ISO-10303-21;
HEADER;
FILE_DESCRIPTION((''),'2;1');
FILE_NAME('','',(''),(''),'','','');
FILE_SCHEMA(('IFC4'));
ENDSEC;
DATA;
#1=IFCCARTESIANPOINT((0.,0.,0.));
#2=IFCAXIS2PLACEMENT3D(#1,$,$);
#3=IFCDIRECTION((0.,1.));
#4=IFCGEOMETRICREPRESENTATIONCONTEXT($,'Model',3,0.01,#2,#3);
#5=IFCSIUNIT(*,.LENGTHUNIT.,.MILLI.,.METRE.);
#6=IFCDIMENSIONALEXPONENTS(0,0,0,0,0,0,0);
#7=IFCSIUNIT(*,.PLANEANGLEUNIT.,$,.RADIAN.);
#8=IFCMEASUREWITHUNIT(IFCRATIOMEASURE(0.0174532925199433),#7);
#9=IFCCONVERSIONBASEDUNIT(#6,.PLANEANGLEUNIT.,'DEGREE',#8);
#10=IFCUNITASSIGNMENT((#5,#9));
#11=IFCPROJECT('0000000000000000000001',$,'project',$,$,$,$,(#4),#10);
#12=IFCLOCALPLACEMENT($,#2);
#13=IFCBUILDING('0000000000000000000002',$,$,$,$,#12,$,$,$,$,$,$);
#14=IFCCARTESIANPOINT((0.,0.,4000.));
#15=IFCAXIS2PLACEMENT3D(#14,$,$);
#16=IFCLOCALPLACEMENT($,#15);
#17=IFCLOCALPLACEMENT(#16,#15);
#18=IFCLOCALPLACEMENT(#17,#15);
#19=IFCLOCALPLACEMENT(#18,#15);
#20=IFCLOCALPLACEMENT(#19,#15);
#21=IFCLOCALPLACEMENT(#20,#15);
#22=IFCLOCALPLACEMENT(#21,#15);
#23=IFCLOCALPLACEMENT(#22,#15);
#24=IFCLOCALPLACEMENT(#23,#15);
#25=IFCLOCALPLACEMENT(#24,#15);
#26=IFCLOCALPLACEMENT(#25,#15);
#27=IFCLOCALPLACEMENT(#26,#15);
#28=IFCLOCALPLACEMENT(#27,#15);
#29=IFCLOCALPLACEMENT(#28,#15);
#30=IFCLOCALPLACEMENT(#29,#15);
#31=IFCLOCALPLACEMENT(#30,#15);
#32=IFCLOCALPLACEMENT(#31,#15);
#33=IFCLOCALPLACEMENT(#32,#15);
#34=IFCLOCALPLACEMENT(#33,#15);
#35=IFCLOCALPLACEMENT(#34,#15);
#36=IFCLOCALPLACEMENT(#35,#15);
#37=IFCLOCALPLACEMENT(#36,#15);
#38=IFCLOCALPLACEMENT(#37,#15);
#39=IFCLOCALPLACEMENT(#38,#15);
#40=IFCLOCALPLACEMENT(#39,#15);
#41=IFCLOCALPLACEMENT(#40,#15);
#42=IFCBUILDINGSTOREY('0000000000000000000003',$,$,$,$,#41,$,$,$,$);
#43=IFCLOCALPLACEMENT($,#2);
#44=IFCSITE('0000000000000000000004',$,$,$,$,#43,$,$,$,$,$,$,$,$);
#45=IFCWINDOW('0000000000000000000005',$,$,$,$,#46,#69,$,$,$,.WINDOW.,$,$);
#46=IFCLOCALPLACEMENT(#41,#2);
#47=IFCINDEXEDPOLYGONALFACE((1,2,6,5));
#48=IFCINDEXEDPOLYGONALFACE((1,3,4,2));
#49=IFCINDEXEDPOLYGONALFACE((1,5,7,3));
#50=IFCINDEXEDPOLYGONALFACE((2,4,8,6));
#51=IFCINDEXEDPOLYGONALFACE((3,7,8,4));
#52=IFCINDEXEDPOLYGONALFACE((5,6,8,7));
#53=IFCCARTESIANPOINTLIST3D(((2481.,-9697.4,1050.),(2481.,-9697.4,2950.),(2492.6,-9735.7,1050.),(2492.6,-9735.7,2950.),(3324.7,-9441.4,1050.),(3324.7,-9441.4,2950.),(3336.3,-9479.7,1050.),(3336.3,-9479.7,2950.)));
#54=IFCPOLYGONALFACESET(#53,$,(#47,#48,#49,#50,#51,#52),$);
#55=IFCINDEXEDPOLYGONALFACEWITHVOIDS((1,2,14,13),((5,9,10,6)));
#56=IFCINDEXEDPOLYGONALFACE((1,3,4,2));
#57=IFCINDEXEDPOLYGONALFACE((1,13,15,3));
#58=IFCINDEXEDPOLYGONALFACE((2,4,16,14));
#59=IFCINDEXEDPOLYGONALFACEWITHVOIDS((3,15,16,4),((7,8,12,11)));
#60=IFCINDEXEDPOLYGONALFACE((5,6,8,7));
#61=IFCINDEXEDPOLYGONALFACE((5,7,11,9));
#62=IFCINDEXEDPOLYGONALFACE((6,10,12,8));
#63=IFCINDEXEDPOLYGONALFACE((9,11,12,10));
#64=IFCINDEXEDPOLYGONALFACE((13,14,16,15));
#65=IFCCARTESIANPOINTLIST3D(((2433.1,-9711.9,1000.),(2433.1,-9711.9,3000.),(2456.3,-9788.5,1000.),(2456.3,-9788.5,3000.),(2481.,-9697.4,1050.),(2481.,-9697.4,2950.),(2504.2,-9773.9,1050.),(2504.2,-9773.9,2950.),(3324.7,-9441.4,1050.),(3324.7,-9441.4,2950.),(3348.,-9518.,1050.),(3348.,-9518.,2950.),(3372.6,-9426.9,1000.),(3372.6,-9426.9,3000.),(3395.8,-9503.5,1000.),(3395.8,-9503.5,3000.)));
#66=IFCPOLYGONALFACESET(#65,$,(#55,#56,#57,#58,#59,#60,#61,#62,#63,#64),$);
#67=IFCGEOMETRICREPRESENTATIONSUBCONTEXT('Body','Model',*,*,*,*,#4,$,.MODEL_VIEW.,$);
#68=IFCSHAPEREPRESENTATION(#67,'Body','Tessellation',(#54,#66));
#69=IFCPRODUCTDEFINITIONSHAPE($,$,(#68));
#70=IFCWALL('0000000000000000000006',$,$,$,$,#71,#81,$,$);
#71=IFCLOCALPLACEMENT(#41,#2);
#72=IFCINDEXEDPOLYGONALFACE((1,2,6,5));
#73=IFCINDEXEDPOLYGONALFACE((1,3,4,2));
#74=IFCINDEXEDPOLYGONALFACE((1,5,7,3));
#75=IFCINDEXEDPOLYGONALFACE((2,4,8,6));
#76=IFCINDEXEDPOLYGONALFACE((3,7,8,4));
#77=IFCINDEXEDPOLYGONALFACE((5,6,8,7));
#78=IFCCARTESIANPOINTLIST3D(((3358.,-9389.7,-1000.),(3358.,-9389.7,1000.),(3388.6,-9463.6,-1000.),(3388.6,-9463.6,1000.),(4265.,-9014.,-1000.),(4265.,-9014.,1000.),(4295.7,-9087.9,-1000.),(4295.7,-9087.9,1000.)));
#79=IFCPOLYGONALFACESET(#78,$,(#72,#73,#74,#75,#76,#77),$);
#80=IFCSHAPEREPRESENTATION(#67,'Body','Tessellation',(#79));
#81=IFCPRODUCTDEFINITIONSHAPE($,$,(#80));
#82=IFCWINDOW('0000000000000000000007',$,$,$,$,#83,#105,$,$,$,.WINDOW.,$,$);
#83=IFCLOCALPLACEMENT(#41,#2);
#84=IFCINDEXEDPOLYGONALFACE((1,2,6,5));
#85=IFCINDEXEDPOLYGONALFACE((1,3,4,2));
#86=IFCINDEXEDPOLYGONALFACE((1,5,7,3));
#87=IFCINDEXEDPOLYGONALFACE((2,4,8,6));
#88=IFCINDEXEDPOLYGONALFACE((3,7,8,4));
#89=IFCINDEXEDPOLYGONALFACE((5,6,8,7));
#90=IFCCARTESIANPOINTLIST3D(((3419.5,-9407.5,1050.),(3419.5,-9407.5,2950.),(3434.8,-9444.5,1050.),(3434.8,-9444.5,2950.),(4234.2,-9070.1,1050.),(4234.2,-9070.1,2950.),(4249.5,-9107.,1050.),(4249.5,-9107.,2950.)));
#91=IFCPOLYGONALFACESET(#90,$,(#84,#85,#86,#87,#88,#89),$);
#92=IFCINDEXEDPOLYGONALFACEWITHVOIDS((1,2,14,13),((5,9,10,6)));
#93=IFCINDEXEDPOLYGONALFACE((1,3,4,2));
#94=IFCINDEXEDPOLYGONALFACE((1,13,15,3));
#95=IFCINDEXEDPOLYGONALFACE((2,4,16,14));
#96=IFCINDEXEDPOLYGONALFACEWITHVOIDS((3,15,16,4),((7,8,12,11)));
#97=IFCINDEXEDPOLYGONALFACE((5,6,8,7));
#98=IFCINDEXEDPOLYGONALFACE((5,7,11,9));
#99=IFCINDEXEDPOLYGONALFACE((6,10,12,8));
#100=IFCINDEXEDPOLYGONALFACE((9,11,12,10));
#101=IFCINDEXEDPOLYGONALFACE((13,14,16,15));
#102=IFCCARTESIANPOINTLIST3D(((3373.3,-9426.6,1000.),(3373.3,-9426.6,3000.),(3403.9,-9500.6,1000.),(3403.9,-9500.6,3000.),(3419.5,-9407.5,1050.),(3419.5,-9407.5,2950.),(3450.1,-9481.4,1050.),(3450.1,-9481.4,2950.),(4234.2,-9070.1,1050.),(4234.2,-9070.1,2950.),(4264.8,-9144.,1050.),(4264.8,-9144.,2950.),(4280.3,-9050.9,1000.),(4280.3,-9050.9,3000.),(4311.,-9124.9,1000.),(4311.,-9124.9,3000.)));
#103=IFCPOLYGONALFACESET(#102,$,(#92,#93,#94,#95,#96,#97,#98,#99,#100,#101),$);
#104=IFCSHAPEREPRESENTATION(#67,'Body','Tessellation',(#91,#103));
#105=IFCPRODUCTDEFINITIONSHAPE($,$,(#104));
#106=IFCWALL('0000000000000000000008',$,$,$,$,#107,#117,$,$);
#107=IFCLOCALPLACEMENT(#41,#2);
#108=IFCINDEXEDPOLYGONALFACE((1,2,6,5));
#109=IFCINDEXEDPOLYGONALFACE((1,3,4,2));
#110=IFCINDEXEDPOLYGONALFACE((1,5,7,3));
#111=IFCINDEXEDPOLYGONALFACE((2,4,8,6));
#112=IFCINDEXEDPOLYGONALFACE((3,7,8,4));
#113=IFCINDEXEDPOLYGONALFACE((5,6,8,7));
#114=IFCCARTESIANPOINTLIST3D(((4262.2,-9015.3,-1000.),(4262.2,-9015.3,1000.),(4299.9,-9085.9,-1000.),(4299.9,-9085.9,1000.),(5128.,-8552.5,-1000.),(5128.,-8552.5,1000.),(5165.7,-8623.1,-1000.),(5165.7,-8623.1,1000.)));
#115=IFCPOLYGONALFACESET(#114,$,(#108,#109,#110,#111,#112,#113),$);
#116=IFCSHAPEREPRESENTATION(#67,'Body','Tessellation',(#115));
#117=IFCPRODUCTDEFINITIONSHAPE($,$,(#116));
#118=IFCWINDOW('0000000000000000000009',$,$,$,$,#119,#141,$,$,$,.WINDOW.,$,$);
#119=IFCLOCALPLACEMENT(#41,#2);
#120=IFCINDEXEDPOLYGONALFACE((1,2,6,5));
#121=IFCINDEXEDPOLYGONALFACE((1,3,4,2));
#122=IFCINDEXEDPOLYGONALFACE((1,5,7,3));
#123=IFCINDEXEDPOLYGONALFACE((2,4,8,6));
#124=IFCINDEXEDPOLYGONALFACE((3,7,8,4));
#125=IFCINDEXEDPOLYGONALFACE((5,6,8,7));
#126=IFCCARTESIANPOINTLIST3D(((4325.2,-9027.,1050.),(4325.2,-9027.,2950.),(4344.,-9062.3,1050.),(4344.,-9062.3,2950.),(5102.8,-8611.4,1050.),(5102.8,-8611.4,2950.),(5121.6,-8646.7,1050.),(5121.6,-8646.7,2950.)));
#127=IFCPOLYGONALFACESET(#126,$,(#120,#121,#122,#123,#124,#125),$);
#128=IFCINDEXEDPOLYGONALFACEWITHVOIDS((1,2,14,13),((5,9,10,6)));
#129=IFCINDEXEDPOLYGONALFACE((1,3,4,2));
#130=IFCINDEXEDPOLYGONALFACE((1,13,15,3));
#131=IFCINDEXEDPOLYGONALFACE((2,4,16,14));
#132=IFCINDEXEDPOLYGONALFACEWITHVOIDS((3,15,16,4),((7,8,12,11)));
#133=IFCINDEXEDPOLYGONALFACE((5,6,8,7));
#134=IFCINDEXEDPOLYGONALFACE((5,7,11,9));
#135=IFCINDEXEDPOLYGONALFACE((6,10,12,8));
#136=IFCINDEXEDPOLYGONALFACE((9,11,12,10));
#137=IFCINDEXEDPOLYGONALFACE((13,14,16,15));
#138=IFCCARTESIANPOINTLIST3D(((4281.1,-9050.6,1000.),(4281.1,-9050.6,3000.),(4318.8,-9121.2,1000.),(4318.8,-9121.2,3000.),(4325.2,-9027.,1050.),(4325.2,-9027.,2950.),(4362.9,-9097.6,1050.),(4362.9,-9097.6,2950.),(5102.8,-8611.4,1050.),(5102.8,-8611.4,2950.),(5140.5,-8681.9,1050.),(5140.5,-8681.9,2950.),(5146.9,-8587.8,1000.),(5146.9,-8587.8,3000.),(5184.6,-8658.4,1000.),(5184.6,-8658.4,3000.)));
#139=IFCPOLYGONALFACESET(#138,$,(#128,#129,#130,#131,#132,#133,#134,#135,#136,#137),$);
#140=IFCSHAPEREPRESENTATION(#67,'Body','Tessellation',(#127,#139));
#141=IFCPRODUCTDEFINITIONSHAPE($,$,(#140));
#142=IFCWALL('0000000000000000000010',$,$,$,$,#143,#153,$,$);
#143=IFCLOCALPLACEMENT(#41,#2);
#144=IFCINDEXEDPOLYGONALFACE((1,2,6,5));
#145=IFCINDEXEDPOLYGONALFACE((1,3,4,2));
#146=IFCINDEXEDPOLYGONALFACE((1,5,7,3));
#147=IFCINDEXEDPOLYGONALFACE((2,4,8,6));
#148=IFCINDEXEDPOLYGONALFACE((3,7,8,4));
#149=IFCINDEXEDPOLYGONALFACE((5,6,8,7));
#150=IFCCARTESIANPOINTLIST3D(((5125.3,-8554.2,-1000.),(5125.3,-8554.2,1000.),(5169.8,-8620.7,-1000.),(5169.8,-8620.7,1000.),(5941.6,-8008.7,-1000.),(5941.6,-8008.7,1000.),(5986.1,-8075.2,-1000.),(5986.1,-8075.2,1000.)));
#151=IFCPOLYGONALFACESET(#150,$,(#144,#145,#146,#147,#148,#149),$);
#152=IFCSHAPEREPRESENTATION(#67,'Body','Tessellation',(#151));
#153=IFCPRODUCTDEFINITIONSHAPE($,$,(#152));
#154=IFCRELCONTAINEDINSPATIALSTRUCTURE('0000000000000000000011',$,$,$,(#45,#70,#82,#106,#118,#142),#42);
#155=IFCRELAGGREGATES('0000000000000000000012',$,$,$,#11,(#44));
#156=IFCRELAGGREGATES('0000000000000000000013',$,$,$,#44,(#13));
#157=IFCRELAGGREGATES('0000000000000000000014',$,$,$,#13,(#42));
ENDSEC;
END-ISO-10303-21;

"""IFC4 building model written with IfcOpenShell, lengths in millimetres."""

from ifc_helpers import new_model, entity, si_unit, converted_unit, direction, frame, origin, origin_2d, place, context, subcontext, project, spatial, rectangle, extrude, element, save


model = new_model("IFC4")

# Units and contexts
model_context = context("Model", 3, precision=0.01, world=origin(), true_north=direction((0.0, 1.0)))
body_context = subcontext(model_context, "Body", "Model", "MODEL_VIEW")
ifc_project = project(units=[si_unit("LENGTHUNIT", "METRE", prefix="MILLI"), converted_unit("PLANEANGLEUNIT", "DEGREE", entity("IfcRatioMeasure", 0.0174532925199433), si_unit("PLANEANGLEUNIT", "RADIAN"), dimensions=[0, 0, 0, 0, 0, 0, 0])], contexts=[model_context])

# Site, building, storey
site_placement = place(None, origin())
site = spatial("IfcSite", under=ifc_project, at=site_placement)
building_placement = place(None, origin())
building = spatial("IfcBuilding", under=site, at=building_placement)
placement_1 = place(None, frame((0.0, 0.0, 4000.0)))
placement_2 = place(placement_1, frame((0.0, 0.0, 4000.0)))
placement_3 = place(placement_2, frame((0.0, 0.0, 4000.0)))
placement_4 = place(placement_3, frame((0.0, 0.0, 4000.0)))
placement_5 = place(placement_4, frame((0.0, 0.0, 4000.0)))
placement_6 = place(placement_5, frame((0.0, 0.0, 4000.0)))
placement_7 = place(placement_6, frame((0.0, 0.0, 4000.0)))
placement_8 = place(placement_7, frame((0.0, 0.0, 4000.0)))
placement_9 = place(placement_8, frame((0.0, 0.0, 4000.0)))
placement_10 = place(placement_9, frame((0.0, 0.0, 4000.0)))
placement_11 = place(placement_10, frame((0.0, 0.0, 4000.0)))
placement_12 = place(placement_11, frame((0.0, 0.0, 4000.0)))
placement_13 = place(placement_12, frame((0.0, 0.0, 4000.0)))
placement_14 = place(placement_13, frame((0.0, 0.0, 4000.0)))
placement_15 = place(placement_14, frame((0.0, 0.0, 4000.0)))
placement_16 = place(placement_15, frame((0.0, 0.0, 4000.0)))
placement_17 = place(placement_16, frame((0.0, 0.0, 4000.0)))
placement_18 = place(placement_17, frame((0.0, 0.0, 4000.0)))
placement_19 = place(placement_18, frame((0.0, 0.0, 4000.0)))
placement_20 = place(placement_19, frame((0.0, 0.0, 4000.0)))
placement_21 = place(placement_20, frame((0.0, 0.0, 4000.0)))
placement_22 = place(placement_21, frame((0.0, 0.0, 4000.0)))
placement_23 = place(placement_22, frame((0.0, 0.0, 4000.0)))
placement_24 = place(placement_23, frame((0.0, 0.0, 4000.0)))
placement_25 = place(placement_24, frame((0.0, 0.0, 4000.0)))
storey_placement = place(placement_25, frame((0.0, 0.0, 4000.0)))
storey = spatial("IfcBuildingStorey", under=building, at=storey_placement)

# Shared definitions
cartesian_point_1 = entity("IfcCartesianPoint", [-440.9, -950.0])
shared_polyline = entity("IfcPolyline", [cartesian_point_1, entity("IfcCartesianPoint", [-440.9, 950.0]), entity("IfcCartesianPoint", [-440.9, 950.0]), entity("IfcCartesianPoint", [440.9, 950.0]), entity("IfcCartesianPoint", [440.9, 950.0]), entity("IfcCartesianPoint", [440.9, -950.0]), entity("IfcCartesianPoint", [440.9, -950.0]), entity("IfcCartesianPoint", [-440.9, -950.0]), cartesian_point_1])

# Window
window_1_placement = place(storey_placement, frame((2902.8, -9569.4, 2000.0), z_axis=(0.0, 0.0, 1.0), x_axis=(9569.403667, 2902.845753, 0.0)))
cartesian_point_2 = entity("IfcCartesianPoint", [-490.9, -1000.0])
element("IfcWindow", 1, at=window_1_placement, inside=storey, PredefinedType="WINDOW", context=body_context, shape_type="SweptSolid", body=[
    entity("IfcExtrudedAreaSolid", entity("IfcArbitraryClosedProfileDef", "AREA", None, shared_polyline), entity("IfcAxis2Placement3D", entity("IfcCartesianPoint", [0.0, 0.0, 0.0]), entity("IfcDirection", [0.0, -1.0, 0.0]), entity("IfcDirection", [1.0, 0.0, 0.0])), entity("IfcDirection", [0.0, 0.0, 1.0]), 40.0),
    entity("IfcExtrudedAreaSolid", entity("IfcArbitraryProfileDefWithVoids", "AREA", None, entity("IfcPolyline", [cartesian_point_2, entity("IfcCartesianPoint", [-490.9, 1000.0]), entity("IfcCartesianPoint", [-490.9, 1000.0]), entity("IfcCartesianPoint", [490.9, 1000.0]), entity("IfcCartesianPoint", [490.9, 1000.0]), entity("IfcCartesianPoint", [490.9, -1000.0]), entity("IfcCartesianPoint", [490.9, -1000.0]), entity("IfcCartesianPoint", [-490.9, -1000.0]), cartesian_point_2]), [shared_polyline]), entity("IfcAxis2Placement3D", entity("IfcCartesianPoint", [0.0, 0.0, 0.0]), entity("IfcDirection", [0.0, -1.0, 0.0]), entity("IfcDirection", [1.0, 0.0, 0.0])), entity("IfcDirection", [0.0, 0.0, 1.0]), 80.0),
])

# Wall
wall_1_placement = place(storey_placement, frame((3826.8, -9238.8, -1000.0), z_axis=(0.0, 0.0, 1.0), x_axis=(9238.794667, 3826.835911, 0.0)))
element("IfcWall", 2, at=wall_1_placement, inside=storey, context=body_context, shape_type="SweptSolid", body=[
    extrude(rectangle(XDim=981.7, YDim=80.0, at=origin_2d()), origin(), (0.0, 0.0, 1.0), 2000.0),
])

# Window
window_2_placement = place(storey_placement, frame((3826.8, -9238.8, 2000.0), z_axis=(0.0, 0.0, 1.0), x_axis=(9238.794667, 3826.835911, 0.0)))
cartesian_point_3 = entity("IfcCartesianPoint", [-490.9, -1000.0])
element("IfcWindow", 3, at=window_2_placement, inside=storey, PredefinedType="WINDOW", context=body_context, shape_type="SweptSolid", body=[
    entity("IfcExtrudedAreaSolid", entity("IfcArbitraryClosedProfileDef", "AREA", None, shared_polyline), entity("IfcAxis2Placement3D", entity("IfcCartesianPoint", [0.0, 0.0, 0.0]), entity("IfcDirection", [0.0, -1.0, 0.0]), entity("IfcDirection", [1.0, 0.0, 0.0])), entity("IfcDirection", [0.0, 0.0, 1.0]), 40.0),
    entity("IfcExtrudedAreaSolid", entity("IfcArbitraryProfileDefWithVoids", "AREA", None, entity("IfcPolyline", [cartesian_point_3, entity("IfcCartesianPoint", [-490.9, 1000.0]), entity("IfcCartesianPoint", [-490.9, 1000.0]), entity("IfcCartesianPoint", [490.9, 1000.0]), entity("IfcCartesianPoint", [490.9, 1000.0]), entity("IfcCartesianPoint", [490.9, -1000.0]), entity("IfcCartesianPoint", [490.9, -1000.0]), entity("IfcCartesianPoint", [-490.9, -1000.0]), cartesian_point_3]), [shared_polyline]), entity("IfcAxis2Placement3D", entity("IfcCartesianPoint", [0.0, 0.0, 0.0]), entity("IfcDirection", [0.0, -1.0, 0.0]), entity("IfcDirection", [1.0, 0.0, 0.0])), entity("IfcDirection", [0.0, 0.0, 1.0]), 80.0),
])

# Wall
wall_2_placement = place(storey_placement, frame((4714.0, -8819.2, -1000.0), z_axis=(0.0, 0.0, 1.0), x_axis=(8819.212769, 4713.967134, 0.0)))
element("IfcWall", 4, at=wall_2_placement, inside=storey, context=body_context, shape_type="SweptSolid", body=[
    extrude(rectangle(XDim=981.7, YDim=80.0, at=origin_2d()), origin(), (0.0, 0.0, 1.0), 2000.0),
])

# Window
window_3_placement = place(storey_placement, frame((4714.0, -8819.2, 2000.0), z_axis=(0.0, 0.0, 1.0), x_axis=(8819.212769, 4713.967134, 0.0)))
cartesian_point_4 = entity("IfcCartesianPoint", [-490.9, -1000.0])
element("IfcWindow", 5, at=window_3_placement, inside=storey, PredefinedType="WINDOW", context=body_context, shape_type="SweptSolid", body=[
    entity("IfcExtrudedAreaSolid", entity("IfcArbitraryClosedProfileDef", "AREA", None, shared_polyline), entity("IfcAxis2Placement3D", entity("IfcCartesianPoint", [0.0, 0.0, 0.0]), entity("IfcDirection", [0.0, -1.0, 0.0]), entity("IfcDirection", [1.0, 0.0, 0.0])), entity("IfcDirection", [0.0, 0.0, 1.0]), 40.0),
    entity("IfcExtrudedAreaSolid", entity("IfcArbitraryProfileDefWithVoids", "AREA", None, entity("IfcPolyline", [cartesian_point_4, entity("IfcCartesianPoint", [-490.9, 1000.0]), entity("IfcCartesianPoint", [-490.9, 1000.0]), entity("IfcCartesianPoint", [490.9, 1000.0]), entity("IfcCartesianPoint", [490.9, 1000.0]), entity("IfcCartesianPoint", [490.9, -1000.0]), entity("IfcCartesianPoint", [490.9, -1000.0]), entity("IfcCartesianPoint", [-490.9, -1000.0]), cartesian_point_4]), [shared_polyline]), entity("IfcAxis2Placement3D", entity("IfcCartesianPoint", [0.0, 0.0, 0.0]), entity("IfcDirection", [0.0, -1.0, 0.0]), entity("IfcDirection", [1.0, 0.0, 0.0])), entity("IfcDirection", [0.0, 0.0, 1.0]), 80.0),
])

# Wall
wall_3_placement = place(storey_placement, frame((5555.7, -8314.7, -1000.0), z_axis=(0.0, 0.0, 1.0), x_axis=(8314.697373, 5555.700459, 0.0)))
element("IfcWall", 6, at=wall_3_placement, inside=storey, context=body_context, shape_type="SweptSolid", body=[
    extrude(rectangle(XDim=981.7, YDim=80.0, at=origin_2d()), origin(), (0.0, 0.0, 1.0), 2000.0),
])

save(model, "model.ifc")
